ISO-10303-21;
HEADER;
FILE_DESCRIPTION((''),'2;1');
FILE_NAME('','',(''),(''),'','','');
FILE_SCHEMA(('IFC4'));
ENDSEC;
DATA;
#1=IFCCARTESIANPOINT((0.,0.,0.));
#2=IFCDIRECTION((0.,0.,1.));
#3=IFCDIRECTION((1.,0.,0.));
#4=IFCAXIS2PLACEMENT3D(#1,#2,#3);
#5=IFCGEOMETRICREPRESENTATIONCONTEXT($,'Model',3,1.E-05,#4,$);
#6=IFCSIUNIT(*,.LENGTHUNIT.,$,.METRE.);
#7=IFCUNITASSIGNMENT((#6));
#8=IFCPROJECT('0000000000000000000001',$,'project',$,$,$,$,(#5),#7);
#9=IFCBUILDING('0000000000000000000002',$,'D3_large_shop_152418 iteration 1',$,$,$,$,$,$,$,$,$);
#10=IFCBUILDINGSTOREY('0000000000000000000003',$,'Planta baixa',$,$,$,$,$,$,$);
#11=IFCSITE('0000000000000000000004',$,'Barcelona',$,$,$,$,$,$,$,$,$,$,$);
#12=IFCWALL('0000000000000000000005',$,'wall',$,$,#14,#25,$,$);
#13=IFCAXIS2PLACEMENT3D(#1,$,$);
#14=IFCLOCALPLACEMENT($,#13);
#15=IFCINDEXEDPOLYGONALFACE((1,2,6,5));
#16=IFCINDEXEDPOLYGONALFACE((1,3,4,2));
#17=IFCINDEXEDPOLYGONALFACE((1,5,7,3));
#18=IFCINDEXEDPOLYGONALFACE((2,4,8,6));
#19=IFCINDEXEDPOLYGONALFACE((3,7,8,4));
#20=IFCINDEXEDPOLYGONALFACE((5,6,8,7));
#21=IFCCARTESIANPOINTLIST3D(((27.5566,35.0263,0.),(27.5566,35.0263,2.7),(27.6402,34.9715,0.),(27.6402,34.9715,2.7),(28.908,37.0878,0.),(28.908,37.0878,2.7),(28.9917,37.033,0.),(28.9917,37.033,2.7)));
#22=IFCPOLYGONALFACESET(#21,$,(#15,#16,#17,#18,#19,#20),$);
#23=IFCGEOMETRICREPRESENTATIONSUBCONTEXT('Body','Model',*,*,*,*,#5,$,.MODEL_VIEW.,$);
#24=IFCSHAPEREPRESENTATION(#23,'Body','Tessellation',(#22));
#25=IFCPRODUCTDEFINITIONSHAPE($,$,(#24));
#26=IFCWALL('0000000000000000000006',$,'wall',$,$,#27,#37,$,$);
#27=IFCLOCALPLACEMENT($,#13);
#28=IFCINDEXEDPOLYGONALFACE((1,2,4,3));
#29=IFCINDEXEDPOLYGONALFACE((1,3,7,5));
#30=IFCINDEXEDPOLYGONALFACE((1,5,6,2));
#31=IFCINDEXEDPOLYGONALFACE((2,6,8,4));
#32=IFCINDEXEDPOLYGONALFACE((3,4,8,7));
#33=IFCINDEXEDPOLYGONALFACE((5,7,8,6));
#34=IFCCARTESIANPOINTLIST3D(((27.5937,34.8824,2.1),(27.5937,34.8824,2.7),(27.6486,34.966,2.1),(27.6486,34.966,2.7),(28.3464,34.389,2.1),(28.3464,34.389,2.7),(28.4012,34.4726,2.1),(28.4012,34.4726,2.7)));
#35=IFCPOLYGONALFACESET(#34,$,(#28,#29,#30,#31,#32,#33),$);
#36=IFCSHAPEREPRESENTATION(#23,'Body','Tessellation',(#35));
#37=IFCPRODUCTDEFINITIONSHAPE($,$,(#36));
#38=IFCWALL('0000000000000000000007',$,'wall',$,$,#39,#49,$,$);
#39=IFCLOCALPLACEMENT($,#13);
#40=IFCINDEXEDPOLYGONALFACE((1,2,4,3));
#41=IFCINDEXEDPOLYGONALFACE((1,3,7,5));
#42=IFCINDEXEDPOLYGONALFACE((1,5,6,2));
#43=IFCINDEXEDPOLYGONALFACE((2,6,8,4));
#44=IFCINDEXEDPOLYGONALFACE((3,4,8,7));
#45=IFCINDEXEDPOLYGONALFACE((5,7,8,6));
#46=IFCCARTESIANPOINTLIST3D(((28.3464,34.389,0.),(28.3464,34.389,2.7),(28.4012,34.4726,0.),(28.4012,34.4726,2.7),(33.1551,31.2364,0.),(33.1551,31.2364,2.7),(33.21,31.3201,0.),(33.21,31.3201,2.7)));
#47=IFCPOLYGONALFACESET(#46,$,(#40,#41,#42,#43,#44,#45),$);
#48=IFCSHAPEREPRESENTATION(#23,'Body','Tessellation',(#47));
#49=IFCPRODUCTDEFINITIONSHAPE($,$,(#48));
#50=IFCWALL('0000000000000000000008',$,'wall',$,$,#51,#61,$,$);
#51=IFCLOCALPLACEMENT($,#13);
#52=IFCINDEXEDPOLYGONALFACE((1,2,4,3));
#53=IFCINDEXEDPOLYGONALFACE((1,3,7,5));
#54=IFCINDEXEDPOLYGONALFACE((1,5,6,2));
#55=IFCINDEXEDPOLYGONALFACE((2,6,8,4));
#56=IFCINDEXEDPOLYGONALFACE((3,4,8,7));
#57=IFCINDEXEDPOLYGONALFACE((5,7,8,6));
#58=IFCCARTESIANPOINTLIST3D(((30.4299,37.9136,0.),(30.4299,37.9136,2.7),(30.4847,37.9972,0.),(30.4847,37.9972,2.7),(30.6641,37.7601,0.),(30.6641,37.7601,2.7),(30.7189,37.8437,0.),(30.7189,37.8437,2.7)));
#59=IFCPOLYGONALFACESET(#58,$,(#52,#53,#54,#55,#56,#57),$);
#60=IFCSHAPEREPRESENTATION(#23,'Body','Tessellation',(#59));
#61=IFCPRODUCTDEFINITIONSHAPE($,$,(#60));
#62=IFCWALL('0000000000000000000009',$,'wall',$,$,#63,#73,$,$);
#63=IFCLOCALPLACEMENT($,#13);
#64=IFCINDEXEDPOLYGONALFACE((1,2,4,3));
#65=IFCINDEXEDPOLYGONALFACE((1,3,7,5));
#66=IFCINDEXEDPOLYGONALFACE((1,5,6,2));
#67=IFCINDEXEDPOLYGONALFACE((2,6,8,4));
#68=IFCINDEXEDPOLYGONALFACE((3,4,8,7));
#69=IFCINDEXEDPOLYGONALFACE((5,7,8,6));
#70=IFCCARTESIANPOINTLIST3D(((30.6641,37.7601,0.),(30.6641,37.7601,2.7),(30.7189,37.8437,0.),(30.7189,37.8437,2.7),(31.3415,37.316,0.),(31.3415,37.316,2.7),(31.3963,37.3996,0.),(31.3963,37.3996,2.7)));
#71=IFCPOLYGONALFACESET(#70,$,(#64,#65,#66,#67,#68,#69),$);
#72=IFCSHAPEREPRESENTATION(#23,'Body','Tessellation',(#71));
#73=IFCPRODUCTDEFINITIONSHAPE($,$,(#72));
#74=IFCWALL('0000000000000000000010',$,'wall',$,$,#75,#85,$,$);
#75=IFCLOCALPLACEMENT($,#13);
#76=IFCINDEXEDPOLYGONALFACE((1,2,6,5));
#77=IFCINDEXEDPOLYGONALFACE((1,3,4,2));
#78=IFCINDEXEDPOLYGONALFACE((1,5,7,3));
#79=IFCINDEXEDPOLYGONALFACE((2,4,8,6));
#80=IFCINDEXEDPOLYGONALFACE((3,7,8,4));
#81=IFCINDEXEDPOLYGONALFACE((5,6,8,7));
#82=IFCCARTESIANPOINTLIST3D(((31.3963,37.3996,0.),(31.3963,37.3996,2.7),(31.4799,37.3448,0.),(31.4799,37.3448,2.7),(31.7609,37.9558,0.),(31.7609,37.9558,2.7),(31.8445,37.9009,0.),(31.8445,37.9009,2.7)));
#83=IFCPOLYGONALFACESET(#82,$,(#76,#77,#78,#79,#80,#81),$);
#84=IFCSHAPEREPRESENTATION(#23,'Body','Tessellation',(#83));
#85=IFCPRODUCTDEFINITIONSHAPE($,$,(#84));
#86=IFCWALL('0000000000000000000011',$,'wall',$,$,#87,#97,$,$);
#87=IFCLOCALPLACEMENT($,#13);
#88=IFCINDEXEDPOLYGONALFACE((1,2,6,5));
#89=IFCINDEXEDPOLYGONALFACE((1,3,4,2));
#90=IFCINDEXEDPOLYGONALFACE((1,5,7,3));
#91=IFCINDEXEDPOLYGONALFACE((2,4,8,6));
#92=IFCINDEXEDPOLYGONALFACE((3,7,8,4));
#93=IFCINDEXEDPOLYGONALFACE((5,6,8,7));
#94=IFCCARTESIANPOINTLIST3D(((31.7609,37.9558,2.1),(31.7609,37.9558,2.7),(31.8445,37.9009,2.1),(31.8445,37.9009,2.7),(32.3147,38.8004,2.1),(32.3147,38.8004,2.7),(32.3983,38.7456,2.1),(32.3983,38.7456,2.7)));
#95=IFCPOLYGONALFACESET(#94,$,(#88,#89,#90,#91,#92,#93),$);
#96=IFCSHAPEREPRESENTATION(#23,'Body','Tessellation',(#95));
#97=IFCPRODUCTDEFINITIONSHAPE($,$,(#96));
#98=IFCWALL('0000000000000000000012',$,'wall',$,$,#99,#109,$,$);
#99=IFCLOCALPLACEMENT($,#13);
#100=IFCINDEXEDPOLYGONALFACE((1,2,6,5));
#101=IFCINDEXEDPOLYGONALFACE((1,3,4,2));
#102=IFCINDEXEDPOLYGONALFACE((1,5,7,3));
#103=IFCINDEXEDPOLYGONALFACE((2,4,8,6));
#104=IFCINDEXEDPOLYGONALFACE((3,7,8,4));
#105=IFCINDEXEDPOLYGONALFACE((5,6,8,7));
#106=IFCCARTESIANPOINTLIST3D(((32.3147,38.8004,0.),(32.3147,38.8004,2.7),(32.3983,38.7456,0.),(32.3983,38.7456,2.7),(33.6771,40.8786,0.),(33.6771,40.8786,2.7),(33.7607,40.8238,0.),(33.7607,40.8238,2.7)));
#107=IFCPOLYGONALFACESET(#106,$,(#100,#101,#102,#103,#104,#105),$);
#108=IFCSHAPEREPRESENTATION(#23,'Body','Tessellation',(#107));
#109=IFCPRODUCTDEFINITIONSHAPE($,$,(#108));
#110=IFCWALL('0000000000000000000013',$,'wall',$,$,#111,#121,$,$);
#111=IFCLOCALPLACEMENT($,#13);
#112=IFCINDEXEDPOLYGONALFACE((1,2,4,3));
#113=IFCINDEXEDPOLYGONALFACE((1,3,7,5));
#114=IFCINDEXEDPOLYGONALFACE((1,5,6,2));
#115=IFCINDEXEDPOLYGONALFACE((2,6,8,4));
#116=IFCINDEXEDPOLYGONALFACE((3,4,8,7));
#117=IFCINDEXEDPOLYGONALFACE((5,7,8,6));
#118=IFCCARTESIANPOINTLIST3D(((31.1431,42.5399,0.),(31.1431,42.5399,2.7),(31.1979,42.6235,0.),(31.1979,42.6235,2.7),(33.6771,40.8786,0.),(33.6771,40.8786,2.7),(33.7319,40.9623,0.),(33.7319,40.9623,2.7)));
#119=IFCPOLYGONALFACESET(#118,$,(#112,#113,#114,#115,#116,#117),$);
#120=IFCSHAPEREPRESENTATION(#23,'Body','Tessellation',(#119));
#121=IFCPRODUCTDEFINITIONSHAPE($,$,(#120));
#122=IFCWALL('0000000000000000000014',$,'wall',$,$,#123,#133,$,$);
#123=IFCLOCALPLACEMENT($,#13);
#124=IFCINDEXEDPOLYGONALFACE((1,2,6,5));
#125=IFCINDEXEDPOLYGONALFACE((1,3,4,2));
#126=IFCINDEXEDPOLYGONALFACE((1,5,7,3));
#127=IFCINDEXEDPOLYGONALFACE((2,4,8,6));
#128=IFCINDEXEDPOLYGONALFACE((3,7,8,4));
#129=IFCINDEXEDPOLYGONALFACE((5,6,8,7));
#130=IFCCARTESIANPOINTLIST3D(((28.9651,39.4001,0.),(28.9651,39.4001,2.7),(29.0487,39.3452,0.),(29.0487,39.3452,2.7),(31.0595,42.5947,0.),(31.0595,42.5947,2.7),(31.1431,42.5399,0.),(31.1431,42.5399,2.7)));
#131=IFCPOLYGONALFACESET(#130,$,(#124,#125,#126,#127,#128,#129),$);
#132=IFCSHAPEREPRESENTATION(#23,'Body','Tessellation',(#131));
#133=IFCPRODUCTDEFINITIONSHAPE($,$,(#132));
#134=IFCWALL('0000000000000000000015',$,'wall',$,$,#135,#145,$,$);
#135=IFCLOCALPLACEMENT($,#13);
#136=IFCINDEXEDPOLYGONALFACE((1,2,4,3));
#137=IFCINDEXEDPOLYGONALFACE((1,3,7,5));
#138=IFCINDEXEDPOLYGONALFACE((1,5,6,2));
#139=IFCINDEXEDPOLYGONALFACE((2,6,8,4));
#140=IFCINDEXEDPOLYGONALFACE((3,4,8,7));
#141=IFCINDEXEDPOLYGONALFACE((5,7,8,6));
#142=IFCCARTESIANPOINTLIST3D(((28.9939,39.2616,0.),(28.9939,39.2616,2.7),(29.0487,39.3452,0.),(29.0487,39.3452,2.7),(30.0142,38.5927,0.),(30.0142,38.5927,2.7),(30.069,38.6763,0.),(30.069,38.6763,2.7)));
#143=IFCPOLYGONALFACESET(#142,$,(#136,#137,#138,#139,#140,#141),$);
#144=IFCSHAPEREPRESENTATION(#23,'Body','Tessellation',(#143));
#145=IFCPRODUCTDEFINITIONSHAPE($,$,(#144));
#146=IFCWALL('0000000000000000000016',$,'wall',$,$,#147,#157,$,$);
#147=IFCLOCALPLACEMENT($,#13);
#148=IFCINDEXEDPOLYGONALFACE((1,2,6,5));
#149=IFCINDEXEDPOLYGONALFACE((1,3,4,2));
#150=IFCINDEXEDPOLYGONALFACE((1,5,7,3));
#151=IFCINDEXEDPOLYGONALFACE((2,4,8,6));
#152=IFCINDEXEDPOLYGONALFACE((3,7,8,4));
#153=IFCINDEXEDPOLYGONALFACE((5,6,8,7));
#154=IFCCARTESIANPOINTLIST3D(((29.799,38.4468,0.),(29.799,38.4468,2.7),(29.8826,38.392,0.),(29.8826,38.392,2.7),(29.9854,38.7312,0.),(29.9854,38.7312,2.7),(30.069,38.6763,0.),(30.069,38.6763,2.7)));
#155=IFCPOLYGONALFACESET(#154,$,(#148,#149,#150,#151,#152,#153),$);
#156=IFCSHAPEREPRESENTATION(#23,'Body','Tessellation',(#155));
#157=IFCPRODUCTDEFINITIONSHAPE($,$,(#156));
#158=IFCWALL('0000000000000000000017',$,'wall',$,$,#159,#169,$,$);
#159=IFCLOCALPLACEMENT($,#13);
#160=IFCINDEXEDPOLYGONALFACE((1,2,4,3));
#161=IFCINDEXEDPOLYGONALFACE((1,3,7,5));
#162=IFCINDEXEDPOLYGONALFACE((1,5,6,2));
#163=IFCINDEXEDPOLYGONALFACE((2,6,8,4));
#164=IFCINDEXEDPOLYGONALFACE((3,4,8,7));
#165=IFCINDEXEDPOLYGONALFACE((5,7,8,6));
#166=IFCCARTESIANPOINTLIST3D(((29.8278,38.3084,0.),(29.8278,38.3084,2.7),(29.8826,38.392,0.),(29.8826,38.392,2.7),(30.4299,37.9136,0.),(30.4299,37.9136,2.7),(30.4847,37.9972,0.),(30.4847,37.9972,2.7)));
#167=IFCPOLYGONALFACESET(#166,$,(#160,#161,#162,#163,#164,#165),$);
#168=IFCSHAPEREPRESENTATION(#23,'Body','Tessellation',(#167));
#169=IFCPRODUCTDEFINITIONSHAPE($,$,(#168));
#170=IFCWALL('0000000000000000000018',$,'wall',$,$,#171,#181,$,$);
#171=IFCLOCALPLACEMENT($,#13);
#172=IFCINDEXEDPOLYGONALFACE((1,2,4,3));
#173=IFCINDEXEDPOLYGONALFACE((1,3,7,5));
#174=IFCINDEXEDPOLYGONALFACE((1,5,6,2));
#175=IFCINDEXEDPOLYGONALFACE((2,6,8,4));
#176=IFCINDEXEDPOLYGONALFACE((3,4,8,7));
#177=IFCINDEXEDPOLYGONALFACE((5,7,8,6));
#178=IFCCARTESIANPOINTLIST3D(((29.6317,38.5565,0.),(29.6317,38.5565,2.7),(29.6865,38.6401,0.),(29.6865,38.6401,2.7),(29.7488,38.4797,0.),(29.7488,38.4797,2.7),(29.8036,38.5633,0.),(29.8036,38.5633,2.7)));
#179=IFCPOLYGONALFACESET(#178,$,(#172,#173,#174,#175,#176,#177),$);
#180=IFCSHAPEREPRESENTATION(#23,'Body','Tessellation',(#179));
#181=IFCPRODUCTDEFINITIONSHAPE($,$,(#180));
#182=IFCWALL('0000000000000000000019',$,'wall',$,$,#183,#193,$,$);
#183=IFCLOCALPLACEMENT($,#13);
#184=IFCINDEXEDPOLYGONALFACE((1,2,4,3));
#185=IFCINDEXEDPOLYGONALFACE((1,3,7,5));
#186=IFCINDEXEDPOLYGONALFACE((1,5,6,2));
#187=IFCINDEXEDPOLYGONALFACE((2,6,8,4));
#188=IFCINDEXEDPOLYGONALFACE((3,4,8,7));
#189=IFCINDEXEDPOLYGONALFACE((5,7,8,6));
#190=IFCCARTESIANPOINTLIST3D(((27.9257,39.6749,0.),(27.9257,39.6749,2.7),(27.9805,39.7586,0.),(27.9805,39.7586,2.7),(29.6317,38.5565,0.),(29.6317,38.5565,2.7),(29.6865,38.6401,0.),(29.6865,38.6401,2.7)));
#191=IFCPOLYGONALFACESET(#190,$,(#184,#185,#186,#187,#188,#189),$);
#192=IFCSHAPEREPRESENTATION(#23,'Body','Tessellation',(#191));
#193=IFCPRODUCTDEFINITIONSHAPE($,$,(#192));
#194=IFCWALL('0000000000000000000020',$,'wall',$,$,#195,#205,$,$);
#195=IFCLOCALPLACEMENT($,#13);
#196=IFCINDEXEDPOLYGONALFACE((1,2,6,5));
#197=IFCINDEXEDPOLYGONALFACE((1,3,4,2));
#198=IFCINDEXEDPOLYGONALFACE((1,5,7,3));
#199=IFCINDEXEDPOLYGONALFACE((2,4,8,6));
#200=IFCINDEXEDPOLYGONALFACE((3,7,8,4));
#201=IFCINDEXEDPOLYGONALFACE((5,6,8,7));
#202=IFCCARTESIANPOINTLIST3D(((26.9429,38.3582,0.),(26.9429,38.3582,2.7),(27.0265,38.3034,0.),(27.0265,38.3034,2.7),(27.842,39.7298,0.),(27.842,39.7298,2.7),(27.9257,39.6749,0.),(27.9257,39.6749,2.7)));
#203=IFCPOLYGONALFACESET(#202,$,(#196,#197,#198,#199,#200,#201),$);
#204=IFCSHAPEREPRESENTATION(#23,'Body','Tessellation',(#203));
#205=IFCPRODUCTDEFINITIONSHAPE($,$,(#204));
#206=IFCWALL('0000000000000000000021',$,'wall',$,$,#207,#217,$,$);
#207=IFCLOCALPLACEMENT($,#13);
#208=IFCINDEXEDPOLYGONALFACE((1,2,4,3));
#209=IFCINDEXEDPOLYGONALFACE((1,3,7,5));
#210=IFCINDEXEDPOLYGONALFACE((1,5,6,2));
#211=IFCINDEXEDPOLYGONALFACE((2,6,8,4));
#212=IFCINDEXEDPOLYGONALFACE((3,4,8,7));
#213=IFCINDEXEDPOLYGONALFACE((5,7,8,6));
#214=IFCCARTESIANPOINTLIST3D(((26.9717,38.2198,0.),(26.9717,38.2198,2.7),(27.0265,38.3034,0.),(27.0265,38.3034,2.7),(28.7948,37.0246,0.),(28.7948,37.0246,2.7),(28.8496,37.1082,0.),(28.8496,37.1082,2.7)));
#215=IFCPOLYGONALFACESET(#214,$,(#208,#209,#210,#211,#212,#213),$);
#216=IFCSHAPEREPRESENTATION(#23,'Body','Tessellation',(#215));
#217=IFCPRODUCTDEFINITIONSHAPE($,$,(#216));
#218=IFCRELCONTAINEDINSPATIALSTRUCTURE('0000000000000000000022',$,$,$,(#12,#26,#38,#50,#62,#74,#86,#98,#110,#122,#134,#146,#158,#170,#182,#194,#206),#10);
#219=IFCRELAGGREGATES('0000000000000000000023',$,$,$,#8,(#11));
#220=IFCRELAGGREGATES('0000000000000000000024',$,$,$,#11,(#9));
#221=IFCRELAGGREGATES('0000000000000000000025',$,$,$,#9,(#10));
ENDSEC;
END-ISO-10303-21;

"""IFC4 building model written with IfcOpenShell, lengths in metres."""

from ifc_helpers import new_model, si_unit, frame, origin, origin_with_axes, place, context, subcontext, project, spatial, polyline, outline, extrude, element, save


model = new_model("IFC4")

# Units and contexts
model_context = context("Model", 3, precision=1e-05, world=origin_with_axes())
body_context = subcontext(model_context, "Body", "Model", "MODEL_VIEW")
ifc_project = project(units=[si_unit("LENGTHUNIT", "METRE")], contexts=[model_context])

# Site, building, storey
site = spatial("IfcSite", under=ifc_project, Name="Barcelona")
building = spatial("IfcBuilding", under=site, Name="D3_large_shop_152418 iteration 1")
storey = spatial("IfcBuildingStorey", under=building, Name="Planta baixa")

# Walls
wall_1_placement = place(None, origin_with_axes())
element("IfcWall", 1, at=wall_1_placement, inside=storey, Name="wall", context=body_context, shape_type="SweptSolid", body=[
    extrude(outline(polyline([(28.9917, 37.033), (27.6402, 34.9715), (27.5566, 35.0263), (28.908, 37.0878), (28.9917, 37.033)])), origin(), (0.0, 0.0, 1.0), 2.7),
])
wall_2_placement = place(None, origin_with_axes())
element("IfcWall", 2, at=wall_2_placement, inside=storey, Name="wall", context=body_context, shape_type="SweptSolid", body=[
    extrude(outline(polyline([(27.6486, 34.966), (28.4012, 34.4726), (28.3464, 34.389), (27.5937, 34.8824), (27.6486, 34.966)])), frame((0.0, 0.0, 2.1)), (0.0, 0.0, 1.0), 0.6),
])
wall_3_placement = place(None, origin_with_axes())
element("IfcWall", 3, at=wall_3_placement, inside=storey, Name="wall", context=body_context, shape_type="SweptSolid", body=[
    extrude(outline(polyline([(28.4012, 34.4726), (33.21, 31.3201), (33.1551, 31.2364), (28.3464, 34.389), (28.4012, 34.4726)])), origin(), (0.0, 0.0, 1.0), 2.7),
])
wall_4_placement = place(None, origin_with_axes())
element("IfcWall", 4, at=wall_4_placement, inside=storey, Name="wall", context=body_context, shape_type="SweptSolid", body=[
    extrude(outline(polyline([(30.4847, 37.9972), (30.7189, 37.8437), (30.6641, 37.7601), (30.4299, 37.9136), (30.4847, 37.9972)])), origin(), (0.0, 0.0, 1.0), 2.7),
])
wall_5_placement = place(None, origin_with_axes())
element("IfcWall", 5, at=wall_5_placement, inside=storey, Name="wall", context=body_context, shape_type="SweptSolid", body=[
    extrude(outline(polyline([(30.7189, 37.8437), (31.3963, 37.3996), (31.3415, 37.316), (30.6641, 37.7601), (30.7189, 37.8437)])), origin(), (0.0, 0.0, 1.0), 2.7),
])
wall_6_placement = place(None, origin_with_axes())
element("IfcWall", 6, at=wall_6_placement, inside=storey, Name="wall", context=body_context, shape_type="SweptSolid", body=[
    extrude(outline(polyline([(31.3963, 37.3996), (31.7609, 37.9558), (31.8445, 37.9009), (31.4799, 37.3448), (31.3963, 37.3996)])), origin(), (0.0, 0.0, 1.0), 2.7),
])
wall_7_placement = place(None, origin_with_axes())
element("IfcWall", 7, at=wall_7_placement, inside=storey, Name="wall", context=body_context, shape_type="SweptSolid", body=[
    extrude(outline(polyline([(31.7609, 37.9558), (32.3147, 38.8004), (32.3983, 38.7456), (31.8445, 37.9009), (31.7609, 37.9558)])), frame((0.0, 0.0, 2.1)), (0.0, 0.0, 1.0), 0.6),
])
wall_8_placement = place(None, origin_with_axes())
element("IfcWall", 8, at=wall_8_placement, inside=storey, Name="wall", context=body_context, shape_type="SweptSolid", body=[
    extrude(outline(polyline([(32.3147, 38.8004), (33.6771, 40.8786), (33.7607, 40.8238), (32.3983, 38.7456), (32.3147, 38.8004)])), origin(), (0.0, 0.0, 1.0), 2.7),
])
wall_9_placement = place(None, origin_with_axes())
element("IfcWall", 9, at=wall_9_placement, inside=storey, Name="wall", context=body_context, shape_type="SweptSolid", body=[
    extrude(outline(polyline([(33.6771, 40.8786), (31.1431, 42.5399), (31.1979, 42.6235), (33.7319, 40.9623), (33.6771, 40.8786)])), origin(), (0.0, 0.0, 1.0), 2.7),
])
wall_10_placement = place(None, origin_with_axes())
element("IfcWall", 10, at=wall_10_placement, inside=storey, Name="wall", context=body_context, shape_type="SweptSolid", body=[
    extrude(outline(polyline([(31.1431, 42.5399), (29.0487, 39.3452), (28.9651, 39.4001), (31.0595, 42.5947), (31.1431, 42.5399)])), origin(), (0.0, 0.0, 1.0), 2.7),
])
wall_11_placement = place(None, origin_with_axes())
element("IfcWall", 11, at=wall_11_placement, inside=storey, Name="wall", context=body_context, shape_type="SweptSolid", body=[
    extrude(outline(polyline([(29.0487, 39.3452), (30.069, 38.6763), (30.0142, 38.5927), (28.9939, 39.2616), (29.0487, 39.3452)])), origin(), (0.0, 0.0, 1.0), 2.7),
])
wall_12_placement = place(None, origin_with_axes())
element("IfcWall", 12, at=wall_12_placement, inside=storey, Name="wall", context=body_context, shape_type="SweptSolid", body=[
    extrude(outline(polyline([(30.069, 38.6763), (29.8826, 38.392), (29.799, 38.4468), (29.9854, 38.7312), (30.069, 38.6763)])), origin(), (0.0, 0.0, 1.0), 2.7),
])
wall_13_placement = place(None, origin_with_axes())
element("IfcWall", 13, at=wall_13_placement, inside=storey, Name="wall", context=body_context, shape_type="SweptSolid", body=[
    extrude(outline(polyline([(29.8826, 38.392), (30.4847, 37.9972), (30.4299, 37.9136), (29.8278, 38.3084), (29.8826, 38.392)])), origin(), (0.0, 0.0, 1.0), 2.7),
])
wall_14_placement = place(None, origin_with_axes())
element("IfcWall", 14, at=wall_14_placement, inside=storey, Name="wall", context=body_context, shape_type="SweptSolid", body=[
    extrude(outline(polyline([(29.7488, 38.4797), (29.6317, 38.5565), (29.6865, 38.6401), (29.8036, 38.5633), (29.7488, 38.4797)])), origin(), (0.0, 0.0, 1.0), 2.7),
])
wall_15_placement = place(None, origin_with_axes())
element("IfcWall", 15, at=wall_15_placement, inside=storey, Name="wall", context=body_context, shape_type="SweptSolid", body=[
    extrude(outline(polyline([(29.6317, 38.5565), (27.9257, 39.6749), (27.9805, 39.7586), (29.6865, 38.6401), (29.6317, 38.5565)])), origin(), (0.0, 0.0, 1.0), 2.7),
])
wall_16_placement = place(None, origin_with_axes())
element("IfcWall", 16, at=wall_16_placement, inside=storey, Name="wall", context=body_context, shape_type="SweptSolid", body=[
    extrude(outline(polyline([(27.9257, 39.6749), (27.0265, 38.3034), (26.9429, 38.3582), (27.842, 39.7298), (27.9257, 39.6749)])), origin(), (0.0, 0.0, 1.0), 2.7),
])
wall_17_placement = place(None, origin_with_axes())
element("IfcWall", 17, at=wall_17_placement, inside=storey, Name="wall", context=body_context, shape_type="SweptSolid", body=[
    extrude(outline(polyline([(27.0265, 38.3034), (28.8496, 37.1082), (28.7948, 37.0246), (26.9717, 38.2198), (27.0265, 38.3034)])), origin(), (0.0, 0.0, 1.0), 2.7),
])

save(model, "model.ifc")
